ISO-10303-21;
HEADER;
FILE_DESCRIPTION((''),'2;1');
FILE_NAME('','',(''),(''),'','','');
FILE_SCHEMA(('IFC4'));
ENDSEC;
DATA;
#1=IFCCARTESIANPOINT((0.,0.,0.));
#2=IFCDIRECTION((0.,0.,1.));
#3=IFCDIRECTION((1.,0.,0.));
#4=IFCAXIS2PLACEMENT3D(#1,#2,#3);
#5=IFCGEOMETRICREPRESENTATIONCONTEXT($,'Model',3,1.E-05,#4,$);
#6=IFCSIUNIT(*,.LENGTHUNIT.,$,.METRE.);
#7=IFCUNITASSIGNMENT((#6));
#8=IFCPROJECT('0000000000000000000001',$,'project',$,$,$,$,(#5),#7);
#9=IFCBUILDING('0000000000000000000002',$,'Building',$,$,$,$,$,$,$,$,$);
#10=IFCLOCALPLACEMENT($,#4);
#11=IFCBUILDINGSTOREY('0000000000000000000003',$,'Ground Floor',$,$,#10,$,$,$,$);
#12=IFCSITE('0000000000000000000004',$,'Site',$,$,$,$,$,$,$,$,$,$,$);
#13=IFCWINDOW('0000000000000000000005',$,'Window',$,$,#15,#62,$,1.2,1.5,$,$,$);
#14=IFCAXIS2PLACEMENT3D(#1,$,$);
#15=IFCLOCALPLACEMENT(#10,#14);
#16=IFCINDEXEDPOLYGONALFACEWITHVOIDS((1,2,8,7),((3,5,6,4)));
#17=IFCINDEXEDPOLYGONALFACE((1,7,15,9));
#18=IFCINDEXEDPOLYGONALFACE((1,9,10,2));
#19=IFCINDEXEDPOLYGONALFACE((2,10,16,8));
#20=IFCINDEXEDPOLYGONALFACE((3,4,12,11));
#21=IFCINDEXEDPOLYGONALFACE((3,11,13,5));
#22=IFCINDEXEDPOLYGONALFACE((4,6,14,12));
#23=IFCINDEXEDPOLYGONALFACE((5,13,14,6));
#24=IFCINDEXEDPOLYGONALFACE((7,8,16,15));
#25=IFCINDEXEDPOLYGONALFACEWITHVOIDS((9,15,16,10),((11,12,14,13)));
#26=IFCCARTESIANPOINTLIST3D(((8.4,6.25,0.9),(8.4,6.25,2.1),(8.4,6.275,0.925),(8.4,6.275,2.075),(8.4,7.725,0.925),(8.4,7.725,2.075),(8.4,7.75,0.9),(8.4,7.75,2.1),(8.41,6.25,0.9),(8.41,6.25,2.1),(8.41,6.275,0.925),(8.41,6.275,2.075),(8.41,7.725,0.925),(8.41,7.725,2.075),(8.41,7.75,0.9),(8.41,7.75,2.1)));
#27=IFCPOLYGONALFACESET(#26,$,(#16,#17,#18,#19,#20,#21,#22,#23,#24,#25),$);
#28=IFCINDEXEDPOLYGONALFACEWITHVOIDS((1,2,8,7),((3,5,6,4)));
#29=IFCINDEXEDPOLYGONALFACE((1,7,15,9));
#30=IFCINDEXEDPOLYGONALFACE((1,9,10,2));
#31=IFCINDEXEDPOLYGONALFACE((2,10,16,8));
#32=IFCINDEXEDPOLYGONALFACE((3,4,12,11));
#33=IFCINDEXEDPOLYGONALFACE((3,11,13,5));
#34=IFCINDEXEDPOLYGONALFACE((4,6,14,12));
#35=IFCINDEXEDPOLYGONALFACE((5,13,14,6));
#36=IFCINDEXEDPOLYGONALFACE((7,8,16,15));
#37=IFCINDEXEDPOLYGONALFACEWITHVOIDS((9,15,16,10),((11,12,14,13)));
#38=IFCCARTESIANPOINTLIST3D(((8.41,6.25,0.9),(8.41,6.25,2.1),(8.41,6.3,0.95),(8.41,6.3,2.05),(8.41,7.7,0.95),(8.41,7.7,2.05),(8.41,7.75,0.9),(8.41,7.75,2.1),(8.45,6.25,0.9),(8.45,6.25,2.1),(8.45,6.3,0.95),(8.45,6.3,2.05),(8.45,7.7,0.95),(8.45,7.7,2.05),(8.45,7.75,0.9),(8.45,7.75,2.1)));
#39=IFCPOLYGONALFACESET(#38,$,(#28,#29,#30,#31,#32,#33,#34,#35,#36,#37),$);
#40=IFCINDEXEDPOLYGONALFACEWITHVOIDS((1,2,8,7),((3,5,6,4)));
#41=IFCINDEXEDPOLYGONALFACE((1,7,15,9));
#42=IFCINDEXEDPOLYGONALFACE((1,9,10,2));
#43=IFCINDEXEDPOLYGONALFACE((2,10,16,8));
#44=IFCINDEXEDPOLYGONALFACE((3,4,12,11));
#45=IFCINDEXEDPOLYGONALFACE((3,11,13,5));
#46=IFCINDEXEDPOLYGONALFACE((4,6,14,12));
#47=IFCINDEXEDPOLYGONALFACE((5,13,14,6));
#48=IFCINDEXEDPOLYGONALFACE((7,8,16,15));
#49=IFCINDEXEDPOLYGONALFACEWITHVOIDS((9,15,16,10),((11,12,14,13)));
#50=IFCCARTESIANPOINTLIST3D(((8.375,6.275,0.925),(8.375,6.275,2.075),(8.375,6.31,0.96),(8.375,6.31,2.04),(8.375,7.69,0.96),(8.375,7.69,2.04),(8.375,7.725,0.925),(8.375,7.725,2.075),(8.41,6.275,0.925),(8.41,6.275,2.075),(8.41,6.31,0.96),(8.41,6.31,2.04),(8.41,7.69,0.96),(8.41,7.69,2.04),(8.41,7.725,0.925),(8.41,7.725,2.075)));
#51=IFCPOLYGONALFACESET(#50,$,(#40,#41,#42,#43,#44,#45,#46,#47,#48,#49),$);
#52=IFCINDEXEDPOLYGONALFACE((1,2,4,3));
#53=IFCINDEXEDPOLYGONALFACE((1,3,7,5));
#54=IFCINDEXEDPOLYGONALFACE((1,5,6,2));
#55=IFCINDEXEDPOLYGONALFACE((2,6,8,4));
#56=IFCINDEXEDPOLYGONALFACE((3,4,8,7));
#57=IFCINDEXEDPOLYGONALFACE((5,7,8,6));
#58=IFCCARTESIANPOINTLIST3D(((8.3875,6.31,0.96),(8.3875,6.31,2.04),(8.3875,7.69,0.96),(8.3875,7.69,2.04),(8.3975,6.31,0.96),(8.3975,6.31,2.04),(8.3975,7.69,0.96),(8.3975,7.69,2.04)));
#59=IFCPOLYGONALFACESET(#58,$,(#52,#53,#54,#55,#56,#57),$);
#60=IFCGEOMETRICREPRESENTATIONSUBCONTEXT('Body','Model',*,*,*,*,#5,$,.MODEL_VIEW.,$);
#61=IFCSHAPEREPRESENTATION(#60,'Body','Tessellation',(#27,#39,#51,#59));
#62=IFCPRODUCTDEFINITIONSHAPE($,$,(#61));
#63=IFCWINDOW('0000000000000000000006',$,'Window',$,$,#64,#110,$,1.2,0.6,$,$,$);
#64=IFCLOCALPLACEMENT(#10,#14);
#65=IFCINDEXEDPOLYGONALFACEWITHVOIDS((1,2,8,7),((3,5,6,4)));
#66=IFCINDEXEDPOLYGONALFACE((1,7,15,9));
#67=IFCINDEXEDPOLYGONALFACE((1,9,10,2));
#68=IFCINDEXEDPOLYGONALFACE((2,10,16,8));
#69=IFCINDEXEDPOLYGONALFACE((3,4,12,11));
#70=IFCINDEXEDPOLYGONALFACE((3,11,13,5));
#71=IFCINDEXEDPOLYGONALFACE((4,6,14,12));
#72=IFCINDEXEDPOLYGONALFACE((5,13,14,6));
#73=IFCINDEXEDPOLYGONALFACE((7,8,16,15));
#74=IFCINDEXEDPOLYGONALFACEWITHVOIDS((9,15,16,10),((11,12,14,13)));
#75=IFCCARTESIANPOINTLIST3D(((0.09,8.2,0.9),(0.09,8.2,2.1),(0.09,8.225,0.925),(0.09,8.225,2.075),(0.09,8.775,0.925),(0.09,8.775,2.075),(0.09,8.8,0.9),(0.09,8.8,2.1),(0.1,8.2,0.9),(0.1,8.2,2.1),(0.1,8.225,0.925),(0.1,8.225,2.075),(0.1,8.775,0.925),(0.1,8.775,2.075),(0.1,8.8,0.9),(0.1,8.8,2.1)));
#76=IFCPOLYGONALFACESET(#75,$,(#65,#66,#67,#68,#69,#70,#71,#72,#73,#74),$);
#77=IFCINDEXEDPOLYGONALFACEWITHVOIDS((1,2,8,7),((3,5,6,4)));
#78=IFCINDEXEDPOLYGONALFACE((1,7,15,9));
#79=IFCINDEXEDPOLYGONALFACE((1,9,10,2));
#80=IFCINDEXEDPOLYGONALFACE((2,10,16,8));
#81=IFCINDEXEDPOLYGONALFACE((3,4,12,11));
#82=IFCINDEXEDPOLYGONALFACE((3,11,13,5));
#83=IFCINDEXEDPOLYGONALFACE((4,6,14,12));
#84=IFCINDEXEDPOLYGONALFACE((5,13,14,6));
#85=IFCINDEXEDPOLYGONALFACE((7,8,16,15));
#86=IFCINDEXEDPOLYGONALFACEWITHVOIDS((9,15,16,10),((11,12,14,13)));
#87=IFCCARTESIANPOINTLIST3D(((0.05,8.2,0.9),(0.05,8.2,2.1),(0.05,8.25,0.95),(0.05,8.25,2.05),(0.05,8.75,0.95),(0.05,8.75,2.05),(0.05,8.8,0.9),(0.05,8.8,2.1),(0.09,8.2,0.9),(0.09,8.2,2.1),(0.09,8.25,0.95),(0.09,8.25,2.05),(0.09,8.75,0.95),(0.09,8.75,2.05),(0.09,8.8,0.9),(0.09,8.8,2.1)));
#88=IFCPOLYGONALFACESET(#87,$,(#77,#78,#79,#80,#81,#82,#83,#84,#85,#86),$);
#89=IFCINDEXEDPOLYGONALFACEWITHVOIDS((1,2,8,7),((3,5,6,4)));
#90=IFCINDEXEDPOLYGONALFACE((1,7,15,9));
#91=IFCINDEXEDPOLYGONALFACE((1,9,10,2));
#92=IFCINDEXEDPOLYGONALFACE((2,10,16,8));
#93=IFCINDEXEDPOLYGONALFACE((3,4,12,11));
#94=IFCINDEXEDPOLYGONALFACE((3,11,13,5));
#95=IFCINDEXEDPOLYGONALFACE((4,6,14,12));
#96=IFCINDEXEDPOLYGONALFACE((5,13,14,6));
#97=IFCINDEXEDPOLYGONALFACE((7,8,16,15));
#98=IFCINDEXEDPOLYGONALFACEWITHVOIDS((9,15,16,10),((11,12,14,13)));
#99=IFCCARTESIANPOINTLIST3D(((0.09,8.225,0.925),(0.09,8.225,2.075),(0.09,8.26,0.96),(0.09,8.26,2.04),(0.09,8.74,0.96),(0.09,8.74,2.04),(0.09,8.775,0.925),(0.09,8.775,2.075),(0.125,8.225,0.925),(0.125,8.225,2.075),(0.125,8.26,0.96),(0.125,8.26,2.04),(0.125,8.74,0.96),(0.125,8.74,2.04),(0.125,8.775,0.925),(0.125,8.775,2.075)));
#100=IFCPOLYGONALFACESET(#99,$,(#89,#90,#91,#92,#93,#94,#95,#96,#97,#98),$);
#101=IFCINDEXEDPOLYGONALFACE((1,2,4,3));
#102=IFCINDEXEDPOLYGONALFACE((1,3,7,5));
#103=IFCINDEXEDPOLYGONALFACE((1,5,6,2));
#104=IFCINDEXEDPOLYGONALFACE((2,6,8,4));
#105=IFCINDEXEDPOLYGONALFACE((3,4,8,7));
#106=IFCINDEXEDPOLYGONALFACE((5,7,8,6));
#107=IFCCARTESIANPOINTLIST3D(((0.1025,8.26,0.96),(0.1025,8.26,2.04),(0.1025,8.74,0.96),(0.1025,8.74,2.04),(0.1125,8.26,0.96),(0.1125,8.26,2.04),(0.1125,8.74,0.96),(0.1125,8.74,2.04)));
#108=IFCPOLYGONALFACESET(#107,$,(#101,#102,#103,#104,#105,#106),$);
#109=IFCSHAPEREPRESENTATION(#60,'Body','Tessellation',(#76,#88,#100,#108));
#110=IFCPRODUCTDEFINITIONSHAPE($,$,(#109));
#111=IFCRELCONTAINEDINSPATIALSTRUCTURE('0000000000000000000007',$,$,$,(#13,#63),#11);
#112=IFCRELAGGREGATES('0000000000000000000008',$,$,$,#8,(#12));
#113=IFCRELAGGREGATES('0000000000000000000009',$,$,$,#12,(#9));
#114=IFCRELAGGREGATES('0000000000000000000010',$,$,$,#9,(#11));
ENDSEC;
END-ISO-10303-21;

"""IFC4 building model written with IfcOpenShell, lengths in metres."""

from ifc_helpers import new_model, si_unit, frame, origin_with_axes, place, context, subcontext, project, spatial, line, indexed_curve, outline, extrude, element, save


model = new_model("IFC4")

# Units and contexts
model_context = context("Model", 3, precision=1e-05, world=origin_with_axes())
body_context = subcontext(model_context, "Body", "Model", "MODEL_VIEW")
ifc_project = project(units=[si_unit("LENGTHUNIT", "METRE")], contexts=[model_context])

# Site, building, storey
site = spatial("IfcSite", under=ifc_project, Name="Site")
building = spatial("IfcBuilding", under=site, Name="Building")
storey_placement = place(None, origin_with_axes())
storey = spatial("IfcBuildingStorey", under=building, at=storey_placement, Name="Ground Floor")

# Windows
window_1_placement = place(storey_placement, frame((8.5, 6.25, 0.9), z_axis=(0.0, 0.0, 1.0), x_axis=(0.0, 1.0, 0.0)))
element("IfcWindow", 1, at=window_1_placement, inside=storey, Name="Window", OverallHeight=1.2, OverallWidth=1.5, context=body_context, shape_type="SweptSolid", body=[
    extrude(outline(indexed_curve([(0.0, 0.0), (1.5, 0.0), (1.5, 1.2), (0.0, 1.2)], segments=[line(1, 2, 3, 4, 1)]), holes=[indexed_curve([(0.025, 0.025), (1.475, 0.025), (1.475, 1.175), (0.025, 1.175)], segments=[line(1, 2, 3, 4, 1)])]), frame((0.0, 0.09, 0.0), z_axis=(0.0, -1.0, 0.0), x_axis=(1.0, 0.0, 0.0)), (0.0, 0.0, -1.0), 0.01),
    extrude(outline(indexed_curve([(0.0, 0.0), (1.5, 0.0), (1.5, 1.2), (0.0, 1.2)], segments=[line(1, 2, 3, 4, 1)]), holes=[indexed_curve([(0.05, 0.05), (1.45, 0.05), (1.45, 1.15), (0.05, 1.15)], segments=[line(1, 2, 3, 4, 1)])]), frame((0.0, 0.05, 0.0), z_axis=(0.0, -1.0, 0.0), x_axis=(1.0, 0.0, 0.0)), (0.0, 0.0, -1.0), 0.04),
    extrude(outline(indexed_curve([(0.0, 0.0), (1.45, 0.0), (1.45, 1.15), (0.0, 1.15)], segments=[line(1, 2, 3, 4, 1)]), holes=[indexed_curve([(0.035, 0.035), (1.415, 0.035), (1.415, 1.115), (0.035, 1.115)], segments=[line(1, 2, 3, 4, 1)])]), frame((0.025, 0.09, 0.025), z_axis=(0.0, -1.0, 0.0), x_axis=(1.0, 0.0, 0.0)), (0.0, 0.0, -1.0), 0.035),
    extrude(outline(indexed_curve([(0.035, 0.035), (1.415, 0.035), (1.415, 1.115), (0.035, 1.115)], segments=[line(1, 2, 3, 4, 1)])), frame((0.025, 0.1025, 0.025), z_axis=(0.0, -1.0, 0.0), x_axis=(1.0, 0.0, 0.0)), (0.0, 0.0, -1.0), 0.01),
])
window_2_placement = place(storey_placement, frame((0.0, 8.8, 0.9), z_axis=(0.0, 0.0, 1.0), x_axis=(0.0, -1.0, 0.0)))
element("IfcWindow", 2, at=window_2_placement, inside=storey, Name="Window", OverallHeight=1.2, OverallWidth=0.6, context=body_context, shape_type="SweptSolid", body=[
    extrude(outline(indexed_curve([(0.0, 0.0), (0.6, 0.0), (0.6, 1.2), (0.0, 1.2)], segments=[line(1, 2, 3, 4, 1)]), holes=[indexed_curve([(0.025, 0.025), (0.575, 0.025), (0.575, 1.175), (0.025, 1.175)], segments=[line(1, 2, 3, 4, 1)])]), frame((0.0, 0.09, 0.0), z_axis=(0.0, -1.0, 0.0), x_axis=(1.0, 0.0, 0.0)), (0.0, 0.0, -1.0), 0.01),
    extrude(outline(indexed_curve([(0.0, 0.0), (0.6, 0.0), (0.6, 1.2), (0.0, 1.2)], segments=[line(1, 2, 3, 4, 1)]), holes=[indexed_curve([(0.05, 0.05), (0.55, 0.05), (0.55, 1.15), (0.05, 1.15)], segments=[line(1, 2, 3, 4, 1)])]), frame((0.0, 0.05, 0.0), z_axis=(0.0, -1.0, 0.0), x_axis=(1.0, 0.0, 0.0)), (0.0, 0.0, -1.0), 0.04),
    extrude(outline(indexed_curve([(0.0, 0.0), (0.55, 0.0), (0.55, 1.15), (0.0, 1.15)], segments=[line(1, 2, 3, 4, 1)]), holes=[indexed_curve([(0.035, 0.035), (0.515, 0.035), (0.515, 1.115), (0.035, 1.115)], segments=[line(1, 2, 3, 4, 1)])]), frame((0.025, 0.09, 0.025), z_axis=(0.0, -1.0, 0.0), x_axis=(1.0, 0.0, 0.0)), (0.0, 0.0, -1.0), 0.035),
    extrude(outline(indexed_curve([(0.035, 0.035), (0.515, 0.035), (0.515, 1.115), (0.035, 1.115)], segments=[line(1, 2, 3, 4, 1)])), frame((0.025, 0.1025, 0.025), z_axis=(0.0, -1.0, 0.0), x_axis=(1.0, 0.0, 0.0)), (0.0, 0.0, -1.0), 0.01),
])

save(model, "model.ifc")
